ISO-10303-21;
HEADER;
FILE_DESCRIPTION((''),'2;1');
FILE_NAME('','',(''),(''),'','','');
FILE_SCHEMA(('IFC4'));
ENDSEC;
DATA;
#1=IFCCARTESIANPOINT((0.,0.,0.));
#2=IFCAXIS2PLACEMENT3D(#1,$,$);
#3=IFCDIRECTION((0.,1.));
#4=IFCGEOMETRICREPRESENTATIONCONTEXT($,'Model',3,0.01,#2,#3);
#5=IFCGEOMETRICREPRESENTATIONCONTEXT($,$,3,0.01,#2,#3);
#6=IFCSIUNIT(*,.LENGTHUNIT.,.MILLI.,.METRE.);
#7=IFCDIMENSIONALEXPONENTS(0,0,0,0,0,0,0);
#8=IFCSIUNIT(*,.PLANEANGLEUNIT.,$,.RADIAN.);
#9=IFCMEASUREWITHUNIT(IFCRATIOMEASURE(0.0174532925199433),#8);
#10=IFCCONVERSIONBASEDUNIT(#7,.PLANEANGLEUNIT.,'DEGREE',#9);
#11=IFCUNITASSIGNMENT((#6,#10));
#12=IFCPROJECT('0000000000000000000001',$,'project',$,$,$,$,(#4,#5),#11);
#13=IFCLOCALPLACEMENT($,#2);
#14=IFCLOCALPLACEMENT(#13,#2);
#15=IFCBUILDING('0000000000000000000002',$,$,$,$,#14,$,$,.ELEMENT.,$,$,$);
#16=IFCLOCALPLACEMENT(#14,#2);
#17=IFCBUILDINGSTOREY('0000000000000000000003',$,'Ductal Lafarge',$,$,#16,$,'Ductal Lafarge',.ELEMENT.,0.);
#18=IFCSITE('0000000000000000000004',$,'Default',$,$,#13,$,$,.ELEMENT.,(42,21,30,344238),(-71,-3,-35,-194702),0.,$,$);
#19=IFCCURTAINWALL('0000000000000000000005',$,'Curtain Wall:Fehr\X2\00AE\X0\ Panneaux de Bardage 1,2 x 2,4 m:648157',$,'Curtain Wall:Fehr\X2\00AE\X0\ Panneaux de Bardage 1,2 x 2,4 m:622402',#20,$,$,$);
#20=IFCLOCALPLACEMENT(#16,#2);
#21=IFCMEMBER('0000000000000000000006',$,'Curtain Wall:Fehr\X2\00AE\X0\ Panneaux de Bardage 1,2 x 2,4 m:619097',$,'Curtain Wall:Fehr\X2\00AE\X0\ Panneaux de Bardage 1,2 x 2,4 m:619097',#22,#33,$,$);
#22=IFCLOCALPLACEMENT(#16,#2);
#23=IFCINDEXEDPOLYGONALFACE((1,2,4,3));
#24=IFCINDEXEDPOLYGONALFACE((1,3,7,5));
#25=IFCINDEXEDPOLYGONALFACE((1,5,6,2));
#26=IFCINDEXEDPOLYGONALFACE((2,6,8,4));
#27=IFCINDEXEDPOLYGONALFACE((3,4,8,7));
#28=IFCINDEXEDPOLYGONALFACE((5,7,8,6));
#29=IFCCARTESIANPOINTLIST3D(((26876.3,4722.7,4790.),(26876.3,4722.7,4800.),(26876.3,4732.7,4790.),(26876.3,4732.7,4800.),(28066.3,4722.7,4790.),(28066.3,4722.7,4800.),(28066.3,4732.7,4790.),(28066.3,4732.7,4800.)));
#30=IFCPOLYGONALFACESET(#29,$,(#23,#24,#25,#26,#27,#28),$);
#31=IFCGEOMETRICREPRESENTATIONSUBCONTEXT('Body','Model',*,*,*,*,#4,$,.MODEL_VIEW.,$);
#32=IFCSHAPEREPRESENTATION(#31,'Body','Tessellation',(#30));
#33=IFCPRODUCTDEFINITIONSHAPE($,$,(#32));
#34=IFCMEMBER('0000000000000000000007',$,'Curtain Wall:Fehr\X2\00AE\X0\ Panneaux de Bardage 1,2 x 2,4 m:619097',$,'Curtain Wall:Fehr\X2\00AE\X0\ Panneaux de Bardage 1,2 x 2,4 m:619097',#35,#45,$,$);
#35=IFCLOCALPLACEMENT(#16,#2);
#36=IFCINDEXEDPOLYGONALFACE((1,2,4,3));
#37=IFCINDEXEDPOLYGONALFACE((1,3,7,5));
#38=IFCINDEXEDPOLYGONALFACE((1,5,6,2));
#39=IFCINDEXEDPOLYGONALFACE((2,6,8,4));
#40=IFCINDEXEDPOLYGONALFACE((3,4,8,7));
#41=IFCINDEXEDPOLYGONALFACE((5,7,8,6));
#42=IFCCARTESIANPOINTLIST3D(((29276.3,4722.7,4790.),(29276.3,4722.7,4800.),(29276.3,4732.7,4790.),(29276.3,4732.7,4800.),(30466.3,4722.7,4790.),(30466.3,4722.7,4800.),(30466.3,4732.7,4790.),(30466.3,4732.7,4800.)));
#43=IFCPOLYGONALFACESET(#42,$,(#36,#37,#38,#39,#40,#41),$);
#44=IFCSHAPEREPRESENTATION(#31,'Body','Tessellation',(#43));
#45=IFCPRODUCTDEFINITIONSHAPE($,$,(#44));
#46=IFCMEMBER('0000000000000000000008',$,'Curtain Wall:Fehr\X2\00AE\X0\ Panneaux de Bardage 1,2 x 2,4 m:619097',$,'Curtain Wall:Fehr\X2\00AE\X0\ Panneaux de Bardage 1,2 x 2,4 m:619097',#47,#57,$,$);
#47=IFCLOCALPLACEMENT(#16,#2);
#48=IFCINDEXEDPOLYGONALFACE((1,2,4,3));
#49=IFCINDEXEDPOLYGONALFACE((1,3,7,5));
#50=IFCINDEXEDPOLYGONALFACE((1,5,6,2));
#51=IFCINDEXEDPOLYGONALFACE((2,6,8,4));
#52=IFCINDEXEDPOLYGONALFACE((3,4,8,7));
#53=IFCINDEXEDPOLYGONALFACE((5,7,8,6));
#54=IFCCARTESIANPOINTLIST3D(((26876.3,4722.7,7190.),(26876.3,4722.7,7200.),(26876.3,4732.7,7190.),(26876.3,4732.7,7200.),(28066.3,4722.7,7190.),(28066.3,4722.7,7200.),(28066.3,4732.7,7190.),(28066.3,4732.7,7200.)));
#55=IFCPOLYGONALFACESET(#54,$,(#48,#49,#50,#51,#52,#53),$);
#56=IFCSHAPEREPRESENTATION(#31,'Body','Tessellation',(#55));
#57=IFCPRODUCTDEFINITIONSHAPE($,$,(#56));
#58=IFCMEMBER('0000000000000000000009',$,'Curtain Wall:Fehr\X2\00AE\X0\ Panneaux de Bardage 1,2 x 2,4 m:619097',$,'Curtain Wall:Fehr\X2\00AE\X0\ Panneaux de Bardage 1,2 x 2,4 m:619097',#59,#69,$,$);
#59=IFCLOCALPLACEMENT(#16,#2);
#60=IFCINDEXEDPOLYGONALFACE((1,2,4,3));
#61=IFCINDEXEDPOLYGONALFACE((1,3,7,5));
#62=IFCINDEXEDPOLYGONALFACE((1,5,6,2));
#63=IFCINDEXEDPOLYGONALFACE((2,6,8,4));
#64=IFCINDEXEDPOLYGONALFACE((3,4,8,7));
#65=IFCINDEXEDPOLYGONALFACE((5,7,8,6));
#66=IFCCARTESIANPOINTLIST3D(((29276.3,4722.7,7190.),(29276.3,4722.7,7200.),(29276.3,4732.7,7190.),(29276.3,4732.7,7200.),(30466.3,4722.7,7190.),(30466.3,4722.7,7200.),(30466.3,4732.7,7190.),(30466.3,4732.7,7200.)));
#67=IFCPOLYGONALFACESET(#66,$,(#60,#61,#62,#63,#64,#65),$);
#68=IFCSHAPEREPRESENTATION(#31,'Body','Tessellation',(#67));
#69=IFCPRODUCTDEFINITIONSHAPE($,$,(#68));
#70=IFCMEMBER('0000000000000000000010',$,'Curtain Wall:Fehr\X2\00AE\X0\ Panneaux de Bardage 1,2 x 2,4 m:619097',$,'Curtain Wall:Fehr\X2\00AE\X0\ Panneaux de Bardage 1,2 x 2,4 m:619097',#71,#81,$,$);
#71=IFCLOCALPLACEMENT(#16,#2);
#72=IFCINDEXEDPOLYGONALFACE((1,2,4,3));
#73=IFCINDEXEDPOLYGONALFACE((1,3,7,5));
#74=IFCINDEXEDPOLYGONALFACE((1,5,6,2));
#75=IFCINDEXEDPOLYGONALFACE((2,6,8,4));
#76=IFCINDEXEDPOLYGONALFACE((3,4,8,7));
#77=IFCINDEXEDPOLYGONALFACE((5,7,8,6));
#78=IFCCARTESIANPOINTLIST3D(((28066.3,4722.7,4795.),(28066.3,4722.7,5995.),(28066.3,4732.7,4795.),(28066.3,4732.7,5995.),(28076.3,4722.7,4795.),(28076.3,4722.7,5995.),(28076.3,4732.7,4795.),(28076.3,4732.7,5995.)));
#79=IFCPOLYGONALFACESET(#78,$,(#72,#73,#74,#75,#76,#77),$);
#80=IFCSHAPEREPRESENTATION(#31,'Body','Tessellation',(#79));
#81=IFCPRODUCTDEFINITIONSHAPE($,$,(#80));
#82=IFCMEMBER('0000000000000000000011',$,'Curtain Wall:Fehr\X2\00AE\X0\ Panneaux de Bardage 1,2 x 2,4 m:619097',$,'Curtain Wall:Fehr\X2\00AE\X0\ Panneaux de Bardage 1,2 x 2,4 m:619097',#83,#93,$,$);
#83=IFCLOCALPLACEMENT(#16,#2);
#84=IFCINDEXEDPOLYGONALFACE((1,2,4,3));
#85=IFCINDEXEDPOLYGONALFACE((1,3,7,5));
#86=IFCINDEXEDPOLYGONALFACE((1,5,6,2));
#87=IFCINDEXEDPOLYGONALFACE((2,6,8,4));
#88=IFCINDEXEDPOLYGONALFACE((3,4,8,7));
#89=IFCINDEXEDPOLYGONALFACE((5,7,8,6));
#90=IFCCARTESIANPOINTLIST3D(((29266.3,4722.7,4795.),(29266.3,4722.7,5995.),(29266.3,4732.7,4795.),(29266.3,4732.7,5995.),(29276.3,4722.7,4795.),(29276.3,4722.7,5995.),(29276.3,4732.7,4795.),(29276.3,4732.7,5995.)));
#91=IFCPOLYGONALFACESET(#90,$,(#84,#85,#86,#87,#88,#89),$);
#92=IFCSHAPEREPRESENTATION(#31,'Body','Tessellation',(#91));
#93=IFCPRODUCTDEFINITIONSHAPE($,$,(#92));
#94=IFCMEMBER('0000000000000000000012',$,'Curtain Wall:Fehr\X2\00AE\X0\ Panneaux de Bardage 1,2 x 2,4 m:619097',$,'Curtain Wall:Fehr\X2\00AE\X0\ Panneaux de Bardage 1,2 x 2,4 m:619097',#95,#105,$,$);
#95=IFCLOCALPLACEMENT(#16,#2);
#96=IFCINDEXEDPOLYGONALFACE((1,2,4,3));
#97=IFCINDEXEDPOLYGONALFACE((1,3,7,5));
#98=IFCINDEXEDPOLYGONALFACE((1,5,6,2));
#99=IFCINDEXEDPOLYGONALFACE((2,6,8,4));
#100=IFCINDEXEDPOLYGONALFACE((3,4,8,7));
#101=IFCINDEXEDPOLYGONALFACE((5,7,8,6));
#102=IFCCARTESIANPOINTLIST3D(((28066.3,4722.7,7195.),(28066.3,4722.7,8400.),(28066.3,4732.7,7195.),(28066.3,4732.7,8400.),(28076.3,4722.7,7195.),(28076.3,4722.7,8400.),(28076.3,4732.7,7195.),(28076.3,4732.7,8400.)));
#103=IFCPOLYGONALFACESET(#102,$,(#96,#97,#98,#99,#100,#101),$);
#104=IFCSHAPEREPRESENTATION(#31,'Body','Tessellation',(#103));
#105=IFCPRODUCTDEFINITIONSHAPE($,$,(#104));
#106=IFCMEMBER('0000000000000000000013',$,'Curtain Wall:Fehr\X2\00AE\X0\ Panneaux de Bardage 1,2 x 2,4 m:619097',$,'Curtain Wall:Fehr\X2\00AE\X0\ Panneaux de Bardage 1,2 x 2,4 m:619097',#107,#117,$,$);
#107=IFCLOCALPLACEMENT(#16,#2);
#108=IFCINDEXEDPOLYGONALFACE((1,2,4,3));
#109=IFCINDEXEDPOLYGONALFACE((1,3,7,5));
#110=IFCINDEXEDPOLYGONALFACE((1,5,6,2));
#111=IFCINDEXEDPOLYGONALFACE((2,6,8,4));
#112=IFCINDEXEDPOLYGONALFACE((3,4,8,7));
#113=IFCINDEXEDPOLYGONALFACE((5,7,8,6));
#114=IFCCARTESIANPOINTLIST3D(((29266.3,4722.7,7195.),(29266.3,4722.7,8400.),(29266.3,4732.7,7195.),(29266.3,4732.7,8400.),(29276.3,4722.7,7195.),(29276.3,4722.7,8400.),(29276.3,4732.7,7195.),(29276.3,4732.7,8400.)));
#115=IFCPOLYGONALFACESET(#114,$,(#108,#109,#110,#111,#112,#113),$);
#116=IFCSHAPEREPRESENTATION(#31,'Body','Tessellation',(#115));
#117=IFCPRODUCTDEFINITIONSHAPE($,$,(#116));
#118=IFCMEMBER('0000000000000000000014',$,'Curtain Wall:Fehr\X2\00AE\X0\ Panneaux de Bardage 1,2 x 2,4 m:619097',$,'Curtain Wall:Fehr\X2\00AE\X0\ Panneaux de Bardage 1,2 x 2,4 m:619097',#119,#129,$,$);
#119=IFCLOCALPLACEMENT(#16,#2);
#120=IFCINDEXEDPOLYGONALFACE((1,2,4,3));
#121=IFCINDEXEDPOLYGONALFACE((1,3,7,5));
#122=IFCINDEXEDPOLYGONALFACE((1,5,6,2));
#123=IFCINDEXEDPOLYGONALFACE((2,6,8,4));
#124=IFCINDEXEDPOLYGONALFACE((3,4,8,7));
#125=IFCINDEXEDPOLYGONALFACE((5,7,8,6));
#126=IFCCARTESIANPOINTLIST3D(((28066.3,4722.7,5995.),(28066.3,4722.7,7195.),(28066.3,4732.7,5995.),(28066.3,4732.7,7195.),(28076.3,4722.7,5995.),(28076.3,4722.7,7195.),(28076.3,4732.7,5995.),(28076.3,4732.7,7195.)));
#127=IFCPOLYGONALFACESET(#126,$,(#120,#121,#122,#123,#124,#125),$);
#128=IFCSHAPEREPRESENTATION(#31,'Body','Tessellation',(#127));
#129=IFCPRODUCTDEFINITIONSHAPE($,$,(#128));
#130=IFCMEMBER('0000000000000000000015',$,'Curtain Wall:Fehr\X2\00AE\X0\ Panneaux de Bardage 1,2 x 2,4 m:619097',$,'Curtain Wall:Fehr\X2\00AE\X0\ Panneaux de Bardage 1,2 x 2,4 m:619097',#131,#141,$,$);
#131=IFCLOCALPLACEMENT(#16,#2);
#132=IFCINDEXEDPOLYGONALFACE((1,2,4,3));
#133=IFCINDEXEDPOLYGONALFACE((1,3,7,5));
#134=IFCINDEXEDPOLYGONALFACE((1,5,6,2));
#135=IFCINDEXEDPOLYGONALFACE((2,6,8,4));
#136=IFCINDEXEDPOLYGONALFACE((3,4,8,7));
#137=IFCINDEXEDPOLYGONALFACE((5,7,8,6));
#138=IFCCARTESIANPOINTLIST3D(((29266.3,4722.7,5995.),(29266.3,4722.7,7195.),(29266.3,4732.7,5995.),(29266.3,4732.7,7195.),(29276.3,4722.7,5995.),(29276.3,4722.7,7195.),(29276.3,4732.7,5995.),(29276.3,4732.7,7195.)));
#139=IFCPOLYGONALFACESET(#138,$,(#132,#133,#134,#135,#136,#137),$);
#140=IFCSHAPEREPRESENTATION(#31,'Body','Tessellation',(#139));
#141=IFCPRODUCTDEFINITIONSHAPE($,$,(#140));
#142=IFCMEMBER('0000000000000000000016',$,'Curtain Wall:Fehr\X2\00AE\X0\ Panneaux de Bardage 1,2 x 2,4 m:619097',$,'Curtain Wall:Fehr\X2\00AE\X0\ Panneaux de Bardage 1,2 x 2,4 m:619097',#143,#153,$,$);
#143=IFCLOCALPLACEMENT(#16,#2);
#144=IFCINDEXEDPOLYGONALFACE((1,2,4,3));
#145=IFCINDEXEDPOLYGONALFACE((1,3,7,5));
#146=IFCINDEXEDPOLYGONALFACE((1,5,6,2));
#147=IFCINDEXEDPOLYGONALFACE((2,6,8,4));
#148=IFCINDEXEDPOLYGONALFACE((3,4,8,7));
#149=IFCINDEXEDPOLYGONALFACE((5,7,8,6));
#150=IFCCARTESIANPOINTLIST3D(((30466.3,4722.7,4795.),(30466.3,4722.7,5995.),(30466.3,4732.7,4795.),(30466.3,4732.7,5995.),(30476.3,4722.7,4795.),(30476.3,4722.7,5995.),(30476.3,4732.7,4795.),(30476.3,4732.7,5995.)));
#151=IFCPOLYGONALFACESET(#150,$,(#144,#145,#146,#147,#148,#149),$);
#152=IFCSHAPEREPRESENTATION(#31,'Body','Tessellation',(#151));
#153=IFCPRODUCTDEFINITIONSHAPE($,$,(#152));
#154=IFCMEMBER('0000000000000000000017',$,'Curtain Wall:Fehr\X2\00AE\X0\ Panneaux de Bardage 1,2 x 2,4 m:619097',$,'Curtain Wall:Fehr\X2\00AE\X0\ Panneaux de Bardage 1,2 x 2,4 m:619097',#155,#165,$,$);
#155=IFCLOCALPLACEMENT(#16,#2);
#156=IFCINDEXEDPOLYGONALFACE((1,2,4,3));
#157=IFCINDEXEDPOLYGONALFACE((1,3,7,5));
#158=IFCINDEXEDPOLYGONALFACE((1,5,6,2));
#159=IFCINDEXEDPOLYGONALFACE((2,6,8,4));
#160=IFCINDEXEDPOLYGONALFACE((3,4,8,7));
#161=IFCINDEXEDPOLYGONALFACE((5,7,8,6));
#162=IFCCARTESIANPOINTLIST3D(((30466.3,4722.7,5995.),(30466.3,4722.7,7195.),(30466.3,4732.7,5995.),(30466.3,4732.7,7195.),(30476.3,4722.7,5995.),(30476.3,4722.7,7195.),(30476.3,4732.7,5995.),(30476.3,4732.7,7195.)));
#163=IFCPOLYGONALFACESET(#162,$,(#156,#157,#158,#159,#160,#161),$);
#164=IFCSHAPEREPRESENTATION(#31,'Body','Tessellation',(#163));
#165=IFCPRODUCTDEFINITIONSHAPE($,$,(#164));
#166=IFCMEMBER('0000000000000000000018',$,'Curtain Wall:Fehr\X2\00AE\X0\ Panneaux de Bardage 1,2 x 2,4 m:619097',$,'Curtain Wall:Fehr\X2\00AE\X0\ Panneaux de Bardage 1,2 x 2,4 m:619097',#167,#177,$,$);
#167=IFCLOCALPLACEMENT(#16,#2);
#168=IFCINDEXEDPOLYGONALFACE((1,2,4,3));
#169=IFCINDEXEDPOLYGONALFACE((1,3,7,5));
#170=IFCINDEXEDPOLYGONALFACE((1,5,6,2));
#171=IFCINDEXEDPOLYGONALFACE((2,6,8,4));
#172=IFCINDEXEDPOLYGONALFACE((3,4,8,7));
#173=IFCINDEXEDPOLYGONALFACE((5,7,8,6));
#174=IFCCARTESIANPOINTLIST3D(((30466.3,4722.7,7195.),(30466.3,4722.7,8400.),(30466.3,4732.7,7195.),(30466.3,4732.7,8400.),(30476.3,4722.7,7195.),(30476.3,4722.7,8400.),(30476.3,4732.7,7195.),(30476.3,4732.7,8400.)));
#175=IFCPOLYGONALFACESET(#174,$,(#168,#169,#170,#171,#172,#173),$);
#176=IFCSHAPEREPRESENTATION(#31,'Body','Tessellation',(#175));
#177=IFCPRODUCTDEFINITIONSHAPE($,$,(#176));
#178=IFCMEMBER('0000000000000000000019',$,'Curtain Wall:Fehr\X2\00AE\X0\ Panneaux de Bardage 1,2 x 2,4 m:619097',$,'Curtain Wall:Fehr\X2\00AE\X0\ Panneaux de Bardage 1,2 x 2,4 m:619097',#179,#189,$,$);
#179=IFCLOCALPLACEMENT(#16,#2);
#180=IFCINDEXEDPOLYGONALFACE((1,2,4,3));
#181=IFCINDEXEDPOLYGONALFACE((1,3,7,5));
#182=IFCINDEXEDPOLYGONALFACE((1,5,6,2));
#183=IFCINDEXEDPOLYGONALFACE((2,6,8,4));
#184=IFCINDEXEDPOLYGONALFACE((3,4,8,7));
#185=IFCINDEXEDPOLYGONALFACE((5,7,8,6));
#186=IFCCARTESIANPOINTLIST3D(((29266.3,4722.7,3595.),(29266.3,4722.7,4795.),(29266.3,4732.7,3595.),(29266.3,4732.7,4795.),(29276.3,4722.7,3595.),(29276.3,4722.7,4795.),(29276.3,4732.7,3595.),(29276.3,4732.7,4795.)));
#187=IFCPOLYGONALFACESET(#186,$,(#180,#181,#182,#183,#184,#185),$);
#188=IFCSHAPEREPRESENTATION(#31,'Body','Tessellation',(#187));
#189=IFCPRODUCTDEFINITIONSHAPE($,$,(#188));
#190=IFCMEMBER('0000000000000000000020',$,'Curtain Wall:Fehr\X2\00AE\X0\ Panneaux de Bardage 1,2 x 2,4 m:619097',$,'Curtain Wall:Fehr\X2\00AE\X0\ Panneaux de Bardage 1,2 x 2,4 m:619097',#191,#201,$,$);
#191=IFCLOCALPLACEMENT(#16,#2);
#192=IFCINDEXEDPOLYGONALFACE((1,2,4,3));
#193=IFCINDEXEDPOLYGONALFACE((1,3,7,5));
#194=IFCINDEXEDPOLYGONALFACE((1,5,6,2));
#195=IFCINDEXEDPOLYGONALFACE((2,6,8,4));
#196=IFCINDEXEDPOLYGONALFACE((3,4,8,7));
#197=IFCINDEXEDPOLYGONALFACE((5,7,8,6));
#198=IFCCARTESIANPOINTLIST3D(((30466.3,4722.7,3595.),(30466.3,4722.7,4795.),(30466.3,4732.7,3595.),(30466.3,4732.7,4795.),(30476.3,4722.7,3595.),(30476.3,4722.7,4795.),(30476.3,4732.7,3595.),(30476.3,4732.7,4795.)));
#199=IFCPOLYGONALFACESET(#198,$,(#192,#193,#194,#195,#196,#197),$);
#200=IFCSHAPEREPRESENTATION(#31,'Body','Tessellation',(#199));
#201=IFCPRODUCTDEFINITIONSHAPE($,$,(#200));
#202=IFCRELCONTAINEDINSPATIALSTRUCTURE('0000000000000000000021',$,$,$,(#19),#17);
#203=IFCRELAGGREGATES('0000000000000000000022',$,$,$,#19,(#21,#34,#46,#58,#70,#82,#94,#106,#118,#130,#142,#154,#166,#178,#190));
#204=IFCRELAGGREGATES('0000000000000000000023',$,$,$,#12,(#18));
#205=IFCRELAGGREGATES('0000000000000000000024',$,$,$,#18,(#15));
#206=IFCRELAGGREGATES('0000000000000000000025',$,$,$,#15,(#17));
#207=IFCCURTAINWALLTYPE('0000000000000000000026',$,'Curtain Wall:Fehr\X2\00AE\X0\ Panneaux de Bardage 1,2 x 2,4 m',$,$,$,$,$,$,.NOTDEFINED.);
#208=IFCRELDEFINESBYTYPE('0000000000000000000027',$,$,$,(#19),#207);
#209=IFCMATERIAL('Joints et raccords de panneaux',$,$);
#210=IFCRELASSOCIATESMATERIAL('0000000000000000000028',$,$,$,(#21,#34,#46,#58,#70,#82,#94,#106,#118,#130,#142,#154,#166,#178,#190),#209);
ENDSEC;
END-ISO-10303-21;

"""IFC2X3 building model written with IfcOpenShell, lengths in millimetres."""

from ifc_helpers import new_model, entity, si_unit, converted_unit, direction, frame, frame_2d, origin, origin_2d_with_axis, place, context, subcontext, project, spatial, rectangle, extrude, material, type_object, element, aggregate, save


model = new_model("IFC2X3")

# Units and contexts
model_context = context("Model", 3, precision=0.01, world=origin(), true_north=direction((0.0, 1.0)))
context_of_model = context(None, 3, precision=0.01, world=origin(), true_north=direction((0.0, 1.0)))
body_context = subcontext(model_context, "Body", "Model", "MODEL_VIEW")
ifc_project = project(units=[si_unit("LENGTHUNIT", "METRE", prefix="MILLI"), converted_unit("PLANEANGLEUNIT", "DEGREE", entity("IfcRatioMeasure", 0.0174532925199433), si_unit("PLANEANGLEUNIT", "RADIAN"), dimensions=[0, 0, 0, 0, 0, 0, 0])], contexts=[model_context, context_of_model])

# Site, building, storey
site_placement = place(None, origin())
site = spatial("IfcSite", under=ifc_project, at=site_placement, Name="Default", CompositionType="ELEMENT", RefLatitude=(42, 21, 30, 344238), RefLongitude=(-71, -3, -35, -194702), RefElevation=0.0)
building_placement = place(site_placement, origin())
building = spatial("IfcBuilding", under=site, at=building_placement, CompositionType="ELEMENT")
storey_placement = place(building_placement, origin())
storey = spatial("IfcBuildingStorey", under=building, at=storey_placement, Name="Ductal Lafarge", LongName="Ductal Lafarge", CompositionType="ELEMENT", Elevation=0.0)

# Curtain wall, members
curtain_wall_type_1 = type_object("IfcCurtainWallType", Name="Curtain Wall:Fehr® Panneaux de Bardage 1,2 x 2,4 m", PredefinedType="NOTDEFINED")
curtain_wall_1_placement = place(storey_placement, origin())
curtain_wall_1 = element("IfcCurtainWall", 1, at=curtain_wall_1_placement, inside=storey, type_object=curtain_wall_type_1, Name="Curtain Wall:Fehr® Panneaux de Bardage 1,2 x 2,4 m:648157", ObjectType="Curtain Wall:Fehr® Panneaux de Bardage 1,2 x 2,4 m:622402")
ifc_material_1 = material(Name="Joints et raccords de panneaux")
member_1_placement = place(curtain_wall_1_placement, frame((26876.3, 4722.7, 4790.0)))
member_1 = element("IfcMember", 2, at=member_1_placement, material=ifc_material_1, Name="Curtain Wall:Fehr® Panneaux de Bardage 1,2 x 2,4 m:619097", ObjectType="Curtain Wall:Fehr® Panneaux de Bardage 1,2 x 2,4 m:619097", context=body_context, shape_type="SweptSolid", body=[
    extrude(rectangle(XDim=1190.0, YDim=10.0, at=frame_2d((0.0, 0.0), x_axis=(1.0, 0.0))), frame((595.0, 5.0, 0.0), z_axis=(0.0, 0.0, 1.0), x_axis=(-1.0, 0.0, 0.0)), (0.0, 0.0, 1.0), 10.0),
])
member_2_placement = place(curtain_wall_1_placement, frame((29276.3, 4722.7, 4790.0)))
member_2 = element("IfcMember", 3, at=member_2_placement, material=ifc_material_1, Name="Curtain Wall:Fehr® Panneaux de Bardage 1,2 x 2,4 m:619097", ObjectType="Curtain Wall:Fehr® Panneaux de Bardage 1,2 x 2,4 m:619097", context=body_context, shape_type="SweptSolid", body=[
    extrude(rectangle(XDim=1190.0, YDim=10.0, at=frame_2d((0.0, 0.0), x_axis=(1.0, 0.0))), frame((595.0, 5.0, 0.0), z_axis=(0.0, 0.0, 1.0), x_axis=(-1.0, 0.0, 0.0)), (0.0, 0.0, 1.0), 10.0),
])
member_3_placement = place(curtain_wall_1_placement, frame((26876.3, 4722.7, 7190.0)))
member_3 = element("IfcMember", 4, at=member_3_placement, material=ifc_material_1, Name="Curtain Wall:Fehr® Panneaux de Bardage 1,2 x 2,4 m:619097", ObjectType="Curtain Wall:Fehr® Panneaux de Bardage 1,2 x 2,4 m:619097", context=body_context, shape_type="SweptSolid", body=[
    extrude(rectangle(XDim=1190.0, YDim=10.0, at=frame_2d((0.0, 0.0), x_axis=(1.0, 0.0))), frame((595.0, 5.0, 0.0), z_axis=(0.0, 0.0, 1.0), x_axis=(-1.0, 0.0, 0.0)), (0.0, 0.0, 1.0), 10.0),
])
member_4_placement = place(curtain_wall_1_placement, frame((29276.3, 4722.7, 7190.0)))
member_4 = element("IfcMember", 5, at=member_4_placement, material=ifc_material_1, Name="Curtain Wall:Fehr® Panneaux de Bardage 1,2 x 2,4 m:619097", ObjectType="Curtain Wall:Fehr® Panneaux de Bardage 1,2 x 2,4 m:619097", context=body_context, shape_type="SweptSolid", body=[
    extrude(rectangle(XDim=1190.0, YDim=10.0, at=frame_2d((0.0, 0.0), x_axis=(1.0, 0.0))), frame((595.0, 5.0, 0.0), z_axis=(0.0, 0.0, 1.0), x_axis=(-1.0, 0.0, 0.0)), (0.0, 0.0, 1.0), 10.0),
])
member_5_placement = place(curtain_wall_1_placement, frame((28066.3, 4722.7, 4795.0)))
member_5 = element("IfcMember", 6, at=member_5_placement, material=ifc_material_1, Name="Curtain Wall:Fehr® Panneaux de Bardage 1,2 x 2,4 m:619097", ObjectType="Curtain Wall:Fehr® Panneaux de Bardage 1,2 x 2,4 m:619097", context=body_context, shape_type="SweptSolid", body=[
    extrude(rectangle(XDim=10.0, YDim=10.0, at=frame_2d((0.0, 0.0), x_axis=(1.0, 0.0))), frame((5.0, 5.0, 0.0), z_axis=(0.0, 0.0, 1.0), x_axis=(0.0, 1.0, 0.0)), (0.0, 0.0, 1.0), 1200.0),
])
member_6_placement = place(curtain_wall_1_placement, frame((29266.3, 4722.7, 4795.0)))
member_6 = element("IfcMember", 7, at=member_6_placement, material=ifc_material_1, Name="Curtain Wall:Fehr® Panneaux de Bardage 1,2 x 2,4 m:619097", ObjectType="Curtain Wall:Fehr® Panneaux de Bardage 1,2 x 2,4 m:619097", context=body_context, shape_type="SweptSolid", body=[
    extrude(rectangle(XDim=10.0, YDim=10.0, at=frame_2d((0.0, 0.0), x_axis=(1.0, 0.0))), frame((5.0, 5.0, 0.0), z_axis=(0.0, 0.0, 1.0), x_axis=(0.0, 1.0, 0.0)), (0.0, 0.0, 1.0), 1200.0),
])
member_7_placement = place(curtain_wall_1_placement, frame((28066.3, 4722.7, 7195.0)))
member_7 = element("IfcMember", 8, at=member_7_placement, material=ifc_material_1, Name="Curtain Wall:Fehr® Panneaux de Bardage 1,2 x 2,4 m:619097", ObjectType="Curtain Wall:Fehr® Panneaux de Bardage 1,2 x 2,4 m:619097", context=body_context, shape_type="SweptSolid", body=[
    extrude(rectangle(XDim=10.0, YDim=10.0, at=origin_2d_with_axis()), frame((5.0, 5.0, 0.0), z_axis=(0.0, 0.0, 1.0), x_axis=(0.0, 1.0, 0.0)), (0.0, 0.0, 1.0), 1205.0),
])
member_8_placement = place(curtain_wall_1_placement, frame((29266.3, 4722.7, 7195.0)))
member_8 = element("IfcMember", 9, at=member_8_placement, material=ifc_material_1, Name="Curtain Wall:Fehr® Panneaux de Bardage 1,2 x 2,4 m:619097", ObjectType="Curtain Wall:Fehr® Panneaux de Bardage 1,2 x 2,4 m:619097", context=body_context, shape_type="SweptSolid", body=[
    extrude(rectangle(XDim=10.0, YDim=10.0, at=origin_2d_with_axis()), frame((5.0, 5.0, 0.0), z_axis=(0.0, 0.0, 1.0), x_axis=(0.0, 1.0, 0.0)), (0.0, 0.0, 1.0), 1205.0),
])
member_9_placement = place(curtain_wall_1_placement, frame((28066.3, 4722.7, 5995.0)))
member_9 = element("IfcMember", 10, at=member_9_placement, material=ifc_material_1, Name="Curtain Wall:Fehr® Panneaux de Bardage 1,2 x 2,4 m:619097", ObjectType="Curtain Wall:Fehr® Panneaux de Bardage 1,2 x 2,4 m:619097", context=body_context, shape_type="SweptSolid", body=[
    extrude(rectangle(XDim=10.0, YDim=10.0, at=frame_2d((0.0, 0.0), x_axis=(1.0, 0.0))), frame((5.0, 5.0, 0.0), z_axis=(0.0, 0.0, 1.0), x_axis=(0.0, 1.0, 0.0)), (0.0, 0.0, 1.0), 1200.0),
])
member_10_placement = place(curtain_wall_1_placement, frame((29266.3, 4722.7, 5995.0)))
member_10 = element("IfcMember", 11, at=member_10_placement, material=ifc_material_1, Name="Curtain Wall:Fehr® Panneaux de Bardage 1,2 x 2,4 m:619097", ObjectType="Curtain Wall:Fehr® Panneaux de Bardage 1,2 x 2,4 m:619097", context=body_context, shape_type="SweptSolid", body=[
    extrude(rectangle(XDim=10.0, YDim=10.0, at=frame_2d((0.0, 0.0), x_axis=(1.0, 0.0))), frame((5.0, 5.0, 0.0), z_axis=(0.0, 0.0, 1.0), x_axis=(0.0, 1.0, 0.0)), (0.0, 0.0, 1.0), 1200.0),
])
member_11_placement = place(curtain_wall_1_placement, frame((30466.3, 4722.7, 4795.0)))
member_11 = element("IfcMember", 12, at=member_11_placement, material=ifc_material_1, Name="Curtain Wall:Fehr® Panneaux de Bardage 1,2 x 2,4 m:619097", ObjectType="Curtain Wall:Fehr® Panneaux de Bardage 1,2 x 2,4 m:619097", context=body_context, shape_type="SweptSolid", body=[
    extrude(rectangle(XDim=10.0, YDim=10.0, at=frame_2d((0.0, 0.0), x_axis=(1.0, 0.0))), frame((5.0, 5.0, 0.0), z_axis=(0.0, 0.0, 1.0), x_axis=(0.0, 1.0, 0.0)), (0.0, 0.0, 1.0), 1200.0),
])
member_12_placement = place(curtain_wall_1_placement, frame((30466.3, 4722.7, 5995.0)))
member_12 = element("IfcMember", 13, at=member_12_placement, material=ifc_material_1, Name="Curtain Wall:Fehr® Panneaux de Bardage 1,2 x 2,4 m:619097", ObjectType="Curtain Wall:Fehr® Panneaux de Bardage 1,2 x 2,4 m:619097", context=body_context, shape_type="SweptSolid", body=[
    extrude(rectangle(XDim=10.0, YDim=10.0, at=frame_2d((0.0, 0.0), x_axis=(1.0, 0.0))), frame((5.0, 5.0, 0.0), z_axis=(0.0, 0.0, 1.0), x_axis=(0.0, 1.0, 0.0)), (0.0, 0.0, 1.0), 1200.0),
])
member_13_placement = place(curtain_wall_1_placement, frame((30466.3, 4722.7, 7195.0)))
member_13 = element("IfcMember", 14, at=member_13_placement, material=ifc_material_1, Name="Curtain Wall:Fehr® Panneaux de Bardage 1,2 x 2,4 m:619097", ObjectType="Curtain Wall:Fehr® Panneaux de Bardage 1,2 x 2,4 m:619097", context=body_context, shape_type="SweptSolid", body=[
    extrude(rectangle(XDim=10.0, YDim=10.0, at=origin_2d_with_axis()), frame((5.0, 5.0, 0.0), z_axis=(0.0, 0.0, 1.0), x_axis=(0.0, 1.0, 0.0)), (0.0, 0.0, 1.0), 1205.0),
])
member_14_placement = place(curtain_wall_1_placement, frame((29266.3, 4722.7, 3595.0)))
member_14 = element("IfcMember", 15, at=member_14_placement, material=ifc_material_1, Name="Curtain Wall:Fehr® Panneaux de Bardage 1,2 x 2,4 m:619097", ObjectType="Curtain Wall:Fehr® Panneaux de Bardage 1,2 x 2,4 m:619097", context=body_context, shape_type="SweptSolid", body=[
    extrude(rectangle(XDim=10.0, YDim=10.0, at=frame_2d((0.0, 0.0), x_axis=(1.0, 0.0))), frame((5.0, 5.0, 0.0), z_axis=(0.0, 0.0, 1.0), x_axis=(0.0, 1.0, 0.0)), (0.0, 0.0, 1.0), 1200.0),
])
member_15_placement = place(curtain_wall_1_placement, frame((30466.3, 4722.7, 3595.0)))
member_15 = element("IfcMember", 16, at=member_15_placement, material=ifc_material_1, Name="Curtain Wall:Fehr® Panneaux de Bardage 1,2 x 2,4 m:619097", ObjectType="Curtain Wall:Fehr® Panneaux de Bardage 1,2 x 2,4 m:619097", context=body_context, shape_type="SweptSolid", body=[
    extrude(rectangle(XDim=10.0, YDim=10.0, at=frame_2d((0.0, 0.0), x_axis=(1.0, 0.0))), frame((5.0, 5.0, 0.0), z_axis=(0.0, 0.0, 1.0), x_axis=(0.0, 1.0, 0.0)), (0.0, 0.0, 1.0), 1200.0),
])

aggregate(curtain_wall_1, [member_1, member_2, member_3, member_4, member_5, member_6, member_7, member_8, member_9, member_10, member_11, member_12, member_13, member_14, member_15])

save(model, "model.ifc")
